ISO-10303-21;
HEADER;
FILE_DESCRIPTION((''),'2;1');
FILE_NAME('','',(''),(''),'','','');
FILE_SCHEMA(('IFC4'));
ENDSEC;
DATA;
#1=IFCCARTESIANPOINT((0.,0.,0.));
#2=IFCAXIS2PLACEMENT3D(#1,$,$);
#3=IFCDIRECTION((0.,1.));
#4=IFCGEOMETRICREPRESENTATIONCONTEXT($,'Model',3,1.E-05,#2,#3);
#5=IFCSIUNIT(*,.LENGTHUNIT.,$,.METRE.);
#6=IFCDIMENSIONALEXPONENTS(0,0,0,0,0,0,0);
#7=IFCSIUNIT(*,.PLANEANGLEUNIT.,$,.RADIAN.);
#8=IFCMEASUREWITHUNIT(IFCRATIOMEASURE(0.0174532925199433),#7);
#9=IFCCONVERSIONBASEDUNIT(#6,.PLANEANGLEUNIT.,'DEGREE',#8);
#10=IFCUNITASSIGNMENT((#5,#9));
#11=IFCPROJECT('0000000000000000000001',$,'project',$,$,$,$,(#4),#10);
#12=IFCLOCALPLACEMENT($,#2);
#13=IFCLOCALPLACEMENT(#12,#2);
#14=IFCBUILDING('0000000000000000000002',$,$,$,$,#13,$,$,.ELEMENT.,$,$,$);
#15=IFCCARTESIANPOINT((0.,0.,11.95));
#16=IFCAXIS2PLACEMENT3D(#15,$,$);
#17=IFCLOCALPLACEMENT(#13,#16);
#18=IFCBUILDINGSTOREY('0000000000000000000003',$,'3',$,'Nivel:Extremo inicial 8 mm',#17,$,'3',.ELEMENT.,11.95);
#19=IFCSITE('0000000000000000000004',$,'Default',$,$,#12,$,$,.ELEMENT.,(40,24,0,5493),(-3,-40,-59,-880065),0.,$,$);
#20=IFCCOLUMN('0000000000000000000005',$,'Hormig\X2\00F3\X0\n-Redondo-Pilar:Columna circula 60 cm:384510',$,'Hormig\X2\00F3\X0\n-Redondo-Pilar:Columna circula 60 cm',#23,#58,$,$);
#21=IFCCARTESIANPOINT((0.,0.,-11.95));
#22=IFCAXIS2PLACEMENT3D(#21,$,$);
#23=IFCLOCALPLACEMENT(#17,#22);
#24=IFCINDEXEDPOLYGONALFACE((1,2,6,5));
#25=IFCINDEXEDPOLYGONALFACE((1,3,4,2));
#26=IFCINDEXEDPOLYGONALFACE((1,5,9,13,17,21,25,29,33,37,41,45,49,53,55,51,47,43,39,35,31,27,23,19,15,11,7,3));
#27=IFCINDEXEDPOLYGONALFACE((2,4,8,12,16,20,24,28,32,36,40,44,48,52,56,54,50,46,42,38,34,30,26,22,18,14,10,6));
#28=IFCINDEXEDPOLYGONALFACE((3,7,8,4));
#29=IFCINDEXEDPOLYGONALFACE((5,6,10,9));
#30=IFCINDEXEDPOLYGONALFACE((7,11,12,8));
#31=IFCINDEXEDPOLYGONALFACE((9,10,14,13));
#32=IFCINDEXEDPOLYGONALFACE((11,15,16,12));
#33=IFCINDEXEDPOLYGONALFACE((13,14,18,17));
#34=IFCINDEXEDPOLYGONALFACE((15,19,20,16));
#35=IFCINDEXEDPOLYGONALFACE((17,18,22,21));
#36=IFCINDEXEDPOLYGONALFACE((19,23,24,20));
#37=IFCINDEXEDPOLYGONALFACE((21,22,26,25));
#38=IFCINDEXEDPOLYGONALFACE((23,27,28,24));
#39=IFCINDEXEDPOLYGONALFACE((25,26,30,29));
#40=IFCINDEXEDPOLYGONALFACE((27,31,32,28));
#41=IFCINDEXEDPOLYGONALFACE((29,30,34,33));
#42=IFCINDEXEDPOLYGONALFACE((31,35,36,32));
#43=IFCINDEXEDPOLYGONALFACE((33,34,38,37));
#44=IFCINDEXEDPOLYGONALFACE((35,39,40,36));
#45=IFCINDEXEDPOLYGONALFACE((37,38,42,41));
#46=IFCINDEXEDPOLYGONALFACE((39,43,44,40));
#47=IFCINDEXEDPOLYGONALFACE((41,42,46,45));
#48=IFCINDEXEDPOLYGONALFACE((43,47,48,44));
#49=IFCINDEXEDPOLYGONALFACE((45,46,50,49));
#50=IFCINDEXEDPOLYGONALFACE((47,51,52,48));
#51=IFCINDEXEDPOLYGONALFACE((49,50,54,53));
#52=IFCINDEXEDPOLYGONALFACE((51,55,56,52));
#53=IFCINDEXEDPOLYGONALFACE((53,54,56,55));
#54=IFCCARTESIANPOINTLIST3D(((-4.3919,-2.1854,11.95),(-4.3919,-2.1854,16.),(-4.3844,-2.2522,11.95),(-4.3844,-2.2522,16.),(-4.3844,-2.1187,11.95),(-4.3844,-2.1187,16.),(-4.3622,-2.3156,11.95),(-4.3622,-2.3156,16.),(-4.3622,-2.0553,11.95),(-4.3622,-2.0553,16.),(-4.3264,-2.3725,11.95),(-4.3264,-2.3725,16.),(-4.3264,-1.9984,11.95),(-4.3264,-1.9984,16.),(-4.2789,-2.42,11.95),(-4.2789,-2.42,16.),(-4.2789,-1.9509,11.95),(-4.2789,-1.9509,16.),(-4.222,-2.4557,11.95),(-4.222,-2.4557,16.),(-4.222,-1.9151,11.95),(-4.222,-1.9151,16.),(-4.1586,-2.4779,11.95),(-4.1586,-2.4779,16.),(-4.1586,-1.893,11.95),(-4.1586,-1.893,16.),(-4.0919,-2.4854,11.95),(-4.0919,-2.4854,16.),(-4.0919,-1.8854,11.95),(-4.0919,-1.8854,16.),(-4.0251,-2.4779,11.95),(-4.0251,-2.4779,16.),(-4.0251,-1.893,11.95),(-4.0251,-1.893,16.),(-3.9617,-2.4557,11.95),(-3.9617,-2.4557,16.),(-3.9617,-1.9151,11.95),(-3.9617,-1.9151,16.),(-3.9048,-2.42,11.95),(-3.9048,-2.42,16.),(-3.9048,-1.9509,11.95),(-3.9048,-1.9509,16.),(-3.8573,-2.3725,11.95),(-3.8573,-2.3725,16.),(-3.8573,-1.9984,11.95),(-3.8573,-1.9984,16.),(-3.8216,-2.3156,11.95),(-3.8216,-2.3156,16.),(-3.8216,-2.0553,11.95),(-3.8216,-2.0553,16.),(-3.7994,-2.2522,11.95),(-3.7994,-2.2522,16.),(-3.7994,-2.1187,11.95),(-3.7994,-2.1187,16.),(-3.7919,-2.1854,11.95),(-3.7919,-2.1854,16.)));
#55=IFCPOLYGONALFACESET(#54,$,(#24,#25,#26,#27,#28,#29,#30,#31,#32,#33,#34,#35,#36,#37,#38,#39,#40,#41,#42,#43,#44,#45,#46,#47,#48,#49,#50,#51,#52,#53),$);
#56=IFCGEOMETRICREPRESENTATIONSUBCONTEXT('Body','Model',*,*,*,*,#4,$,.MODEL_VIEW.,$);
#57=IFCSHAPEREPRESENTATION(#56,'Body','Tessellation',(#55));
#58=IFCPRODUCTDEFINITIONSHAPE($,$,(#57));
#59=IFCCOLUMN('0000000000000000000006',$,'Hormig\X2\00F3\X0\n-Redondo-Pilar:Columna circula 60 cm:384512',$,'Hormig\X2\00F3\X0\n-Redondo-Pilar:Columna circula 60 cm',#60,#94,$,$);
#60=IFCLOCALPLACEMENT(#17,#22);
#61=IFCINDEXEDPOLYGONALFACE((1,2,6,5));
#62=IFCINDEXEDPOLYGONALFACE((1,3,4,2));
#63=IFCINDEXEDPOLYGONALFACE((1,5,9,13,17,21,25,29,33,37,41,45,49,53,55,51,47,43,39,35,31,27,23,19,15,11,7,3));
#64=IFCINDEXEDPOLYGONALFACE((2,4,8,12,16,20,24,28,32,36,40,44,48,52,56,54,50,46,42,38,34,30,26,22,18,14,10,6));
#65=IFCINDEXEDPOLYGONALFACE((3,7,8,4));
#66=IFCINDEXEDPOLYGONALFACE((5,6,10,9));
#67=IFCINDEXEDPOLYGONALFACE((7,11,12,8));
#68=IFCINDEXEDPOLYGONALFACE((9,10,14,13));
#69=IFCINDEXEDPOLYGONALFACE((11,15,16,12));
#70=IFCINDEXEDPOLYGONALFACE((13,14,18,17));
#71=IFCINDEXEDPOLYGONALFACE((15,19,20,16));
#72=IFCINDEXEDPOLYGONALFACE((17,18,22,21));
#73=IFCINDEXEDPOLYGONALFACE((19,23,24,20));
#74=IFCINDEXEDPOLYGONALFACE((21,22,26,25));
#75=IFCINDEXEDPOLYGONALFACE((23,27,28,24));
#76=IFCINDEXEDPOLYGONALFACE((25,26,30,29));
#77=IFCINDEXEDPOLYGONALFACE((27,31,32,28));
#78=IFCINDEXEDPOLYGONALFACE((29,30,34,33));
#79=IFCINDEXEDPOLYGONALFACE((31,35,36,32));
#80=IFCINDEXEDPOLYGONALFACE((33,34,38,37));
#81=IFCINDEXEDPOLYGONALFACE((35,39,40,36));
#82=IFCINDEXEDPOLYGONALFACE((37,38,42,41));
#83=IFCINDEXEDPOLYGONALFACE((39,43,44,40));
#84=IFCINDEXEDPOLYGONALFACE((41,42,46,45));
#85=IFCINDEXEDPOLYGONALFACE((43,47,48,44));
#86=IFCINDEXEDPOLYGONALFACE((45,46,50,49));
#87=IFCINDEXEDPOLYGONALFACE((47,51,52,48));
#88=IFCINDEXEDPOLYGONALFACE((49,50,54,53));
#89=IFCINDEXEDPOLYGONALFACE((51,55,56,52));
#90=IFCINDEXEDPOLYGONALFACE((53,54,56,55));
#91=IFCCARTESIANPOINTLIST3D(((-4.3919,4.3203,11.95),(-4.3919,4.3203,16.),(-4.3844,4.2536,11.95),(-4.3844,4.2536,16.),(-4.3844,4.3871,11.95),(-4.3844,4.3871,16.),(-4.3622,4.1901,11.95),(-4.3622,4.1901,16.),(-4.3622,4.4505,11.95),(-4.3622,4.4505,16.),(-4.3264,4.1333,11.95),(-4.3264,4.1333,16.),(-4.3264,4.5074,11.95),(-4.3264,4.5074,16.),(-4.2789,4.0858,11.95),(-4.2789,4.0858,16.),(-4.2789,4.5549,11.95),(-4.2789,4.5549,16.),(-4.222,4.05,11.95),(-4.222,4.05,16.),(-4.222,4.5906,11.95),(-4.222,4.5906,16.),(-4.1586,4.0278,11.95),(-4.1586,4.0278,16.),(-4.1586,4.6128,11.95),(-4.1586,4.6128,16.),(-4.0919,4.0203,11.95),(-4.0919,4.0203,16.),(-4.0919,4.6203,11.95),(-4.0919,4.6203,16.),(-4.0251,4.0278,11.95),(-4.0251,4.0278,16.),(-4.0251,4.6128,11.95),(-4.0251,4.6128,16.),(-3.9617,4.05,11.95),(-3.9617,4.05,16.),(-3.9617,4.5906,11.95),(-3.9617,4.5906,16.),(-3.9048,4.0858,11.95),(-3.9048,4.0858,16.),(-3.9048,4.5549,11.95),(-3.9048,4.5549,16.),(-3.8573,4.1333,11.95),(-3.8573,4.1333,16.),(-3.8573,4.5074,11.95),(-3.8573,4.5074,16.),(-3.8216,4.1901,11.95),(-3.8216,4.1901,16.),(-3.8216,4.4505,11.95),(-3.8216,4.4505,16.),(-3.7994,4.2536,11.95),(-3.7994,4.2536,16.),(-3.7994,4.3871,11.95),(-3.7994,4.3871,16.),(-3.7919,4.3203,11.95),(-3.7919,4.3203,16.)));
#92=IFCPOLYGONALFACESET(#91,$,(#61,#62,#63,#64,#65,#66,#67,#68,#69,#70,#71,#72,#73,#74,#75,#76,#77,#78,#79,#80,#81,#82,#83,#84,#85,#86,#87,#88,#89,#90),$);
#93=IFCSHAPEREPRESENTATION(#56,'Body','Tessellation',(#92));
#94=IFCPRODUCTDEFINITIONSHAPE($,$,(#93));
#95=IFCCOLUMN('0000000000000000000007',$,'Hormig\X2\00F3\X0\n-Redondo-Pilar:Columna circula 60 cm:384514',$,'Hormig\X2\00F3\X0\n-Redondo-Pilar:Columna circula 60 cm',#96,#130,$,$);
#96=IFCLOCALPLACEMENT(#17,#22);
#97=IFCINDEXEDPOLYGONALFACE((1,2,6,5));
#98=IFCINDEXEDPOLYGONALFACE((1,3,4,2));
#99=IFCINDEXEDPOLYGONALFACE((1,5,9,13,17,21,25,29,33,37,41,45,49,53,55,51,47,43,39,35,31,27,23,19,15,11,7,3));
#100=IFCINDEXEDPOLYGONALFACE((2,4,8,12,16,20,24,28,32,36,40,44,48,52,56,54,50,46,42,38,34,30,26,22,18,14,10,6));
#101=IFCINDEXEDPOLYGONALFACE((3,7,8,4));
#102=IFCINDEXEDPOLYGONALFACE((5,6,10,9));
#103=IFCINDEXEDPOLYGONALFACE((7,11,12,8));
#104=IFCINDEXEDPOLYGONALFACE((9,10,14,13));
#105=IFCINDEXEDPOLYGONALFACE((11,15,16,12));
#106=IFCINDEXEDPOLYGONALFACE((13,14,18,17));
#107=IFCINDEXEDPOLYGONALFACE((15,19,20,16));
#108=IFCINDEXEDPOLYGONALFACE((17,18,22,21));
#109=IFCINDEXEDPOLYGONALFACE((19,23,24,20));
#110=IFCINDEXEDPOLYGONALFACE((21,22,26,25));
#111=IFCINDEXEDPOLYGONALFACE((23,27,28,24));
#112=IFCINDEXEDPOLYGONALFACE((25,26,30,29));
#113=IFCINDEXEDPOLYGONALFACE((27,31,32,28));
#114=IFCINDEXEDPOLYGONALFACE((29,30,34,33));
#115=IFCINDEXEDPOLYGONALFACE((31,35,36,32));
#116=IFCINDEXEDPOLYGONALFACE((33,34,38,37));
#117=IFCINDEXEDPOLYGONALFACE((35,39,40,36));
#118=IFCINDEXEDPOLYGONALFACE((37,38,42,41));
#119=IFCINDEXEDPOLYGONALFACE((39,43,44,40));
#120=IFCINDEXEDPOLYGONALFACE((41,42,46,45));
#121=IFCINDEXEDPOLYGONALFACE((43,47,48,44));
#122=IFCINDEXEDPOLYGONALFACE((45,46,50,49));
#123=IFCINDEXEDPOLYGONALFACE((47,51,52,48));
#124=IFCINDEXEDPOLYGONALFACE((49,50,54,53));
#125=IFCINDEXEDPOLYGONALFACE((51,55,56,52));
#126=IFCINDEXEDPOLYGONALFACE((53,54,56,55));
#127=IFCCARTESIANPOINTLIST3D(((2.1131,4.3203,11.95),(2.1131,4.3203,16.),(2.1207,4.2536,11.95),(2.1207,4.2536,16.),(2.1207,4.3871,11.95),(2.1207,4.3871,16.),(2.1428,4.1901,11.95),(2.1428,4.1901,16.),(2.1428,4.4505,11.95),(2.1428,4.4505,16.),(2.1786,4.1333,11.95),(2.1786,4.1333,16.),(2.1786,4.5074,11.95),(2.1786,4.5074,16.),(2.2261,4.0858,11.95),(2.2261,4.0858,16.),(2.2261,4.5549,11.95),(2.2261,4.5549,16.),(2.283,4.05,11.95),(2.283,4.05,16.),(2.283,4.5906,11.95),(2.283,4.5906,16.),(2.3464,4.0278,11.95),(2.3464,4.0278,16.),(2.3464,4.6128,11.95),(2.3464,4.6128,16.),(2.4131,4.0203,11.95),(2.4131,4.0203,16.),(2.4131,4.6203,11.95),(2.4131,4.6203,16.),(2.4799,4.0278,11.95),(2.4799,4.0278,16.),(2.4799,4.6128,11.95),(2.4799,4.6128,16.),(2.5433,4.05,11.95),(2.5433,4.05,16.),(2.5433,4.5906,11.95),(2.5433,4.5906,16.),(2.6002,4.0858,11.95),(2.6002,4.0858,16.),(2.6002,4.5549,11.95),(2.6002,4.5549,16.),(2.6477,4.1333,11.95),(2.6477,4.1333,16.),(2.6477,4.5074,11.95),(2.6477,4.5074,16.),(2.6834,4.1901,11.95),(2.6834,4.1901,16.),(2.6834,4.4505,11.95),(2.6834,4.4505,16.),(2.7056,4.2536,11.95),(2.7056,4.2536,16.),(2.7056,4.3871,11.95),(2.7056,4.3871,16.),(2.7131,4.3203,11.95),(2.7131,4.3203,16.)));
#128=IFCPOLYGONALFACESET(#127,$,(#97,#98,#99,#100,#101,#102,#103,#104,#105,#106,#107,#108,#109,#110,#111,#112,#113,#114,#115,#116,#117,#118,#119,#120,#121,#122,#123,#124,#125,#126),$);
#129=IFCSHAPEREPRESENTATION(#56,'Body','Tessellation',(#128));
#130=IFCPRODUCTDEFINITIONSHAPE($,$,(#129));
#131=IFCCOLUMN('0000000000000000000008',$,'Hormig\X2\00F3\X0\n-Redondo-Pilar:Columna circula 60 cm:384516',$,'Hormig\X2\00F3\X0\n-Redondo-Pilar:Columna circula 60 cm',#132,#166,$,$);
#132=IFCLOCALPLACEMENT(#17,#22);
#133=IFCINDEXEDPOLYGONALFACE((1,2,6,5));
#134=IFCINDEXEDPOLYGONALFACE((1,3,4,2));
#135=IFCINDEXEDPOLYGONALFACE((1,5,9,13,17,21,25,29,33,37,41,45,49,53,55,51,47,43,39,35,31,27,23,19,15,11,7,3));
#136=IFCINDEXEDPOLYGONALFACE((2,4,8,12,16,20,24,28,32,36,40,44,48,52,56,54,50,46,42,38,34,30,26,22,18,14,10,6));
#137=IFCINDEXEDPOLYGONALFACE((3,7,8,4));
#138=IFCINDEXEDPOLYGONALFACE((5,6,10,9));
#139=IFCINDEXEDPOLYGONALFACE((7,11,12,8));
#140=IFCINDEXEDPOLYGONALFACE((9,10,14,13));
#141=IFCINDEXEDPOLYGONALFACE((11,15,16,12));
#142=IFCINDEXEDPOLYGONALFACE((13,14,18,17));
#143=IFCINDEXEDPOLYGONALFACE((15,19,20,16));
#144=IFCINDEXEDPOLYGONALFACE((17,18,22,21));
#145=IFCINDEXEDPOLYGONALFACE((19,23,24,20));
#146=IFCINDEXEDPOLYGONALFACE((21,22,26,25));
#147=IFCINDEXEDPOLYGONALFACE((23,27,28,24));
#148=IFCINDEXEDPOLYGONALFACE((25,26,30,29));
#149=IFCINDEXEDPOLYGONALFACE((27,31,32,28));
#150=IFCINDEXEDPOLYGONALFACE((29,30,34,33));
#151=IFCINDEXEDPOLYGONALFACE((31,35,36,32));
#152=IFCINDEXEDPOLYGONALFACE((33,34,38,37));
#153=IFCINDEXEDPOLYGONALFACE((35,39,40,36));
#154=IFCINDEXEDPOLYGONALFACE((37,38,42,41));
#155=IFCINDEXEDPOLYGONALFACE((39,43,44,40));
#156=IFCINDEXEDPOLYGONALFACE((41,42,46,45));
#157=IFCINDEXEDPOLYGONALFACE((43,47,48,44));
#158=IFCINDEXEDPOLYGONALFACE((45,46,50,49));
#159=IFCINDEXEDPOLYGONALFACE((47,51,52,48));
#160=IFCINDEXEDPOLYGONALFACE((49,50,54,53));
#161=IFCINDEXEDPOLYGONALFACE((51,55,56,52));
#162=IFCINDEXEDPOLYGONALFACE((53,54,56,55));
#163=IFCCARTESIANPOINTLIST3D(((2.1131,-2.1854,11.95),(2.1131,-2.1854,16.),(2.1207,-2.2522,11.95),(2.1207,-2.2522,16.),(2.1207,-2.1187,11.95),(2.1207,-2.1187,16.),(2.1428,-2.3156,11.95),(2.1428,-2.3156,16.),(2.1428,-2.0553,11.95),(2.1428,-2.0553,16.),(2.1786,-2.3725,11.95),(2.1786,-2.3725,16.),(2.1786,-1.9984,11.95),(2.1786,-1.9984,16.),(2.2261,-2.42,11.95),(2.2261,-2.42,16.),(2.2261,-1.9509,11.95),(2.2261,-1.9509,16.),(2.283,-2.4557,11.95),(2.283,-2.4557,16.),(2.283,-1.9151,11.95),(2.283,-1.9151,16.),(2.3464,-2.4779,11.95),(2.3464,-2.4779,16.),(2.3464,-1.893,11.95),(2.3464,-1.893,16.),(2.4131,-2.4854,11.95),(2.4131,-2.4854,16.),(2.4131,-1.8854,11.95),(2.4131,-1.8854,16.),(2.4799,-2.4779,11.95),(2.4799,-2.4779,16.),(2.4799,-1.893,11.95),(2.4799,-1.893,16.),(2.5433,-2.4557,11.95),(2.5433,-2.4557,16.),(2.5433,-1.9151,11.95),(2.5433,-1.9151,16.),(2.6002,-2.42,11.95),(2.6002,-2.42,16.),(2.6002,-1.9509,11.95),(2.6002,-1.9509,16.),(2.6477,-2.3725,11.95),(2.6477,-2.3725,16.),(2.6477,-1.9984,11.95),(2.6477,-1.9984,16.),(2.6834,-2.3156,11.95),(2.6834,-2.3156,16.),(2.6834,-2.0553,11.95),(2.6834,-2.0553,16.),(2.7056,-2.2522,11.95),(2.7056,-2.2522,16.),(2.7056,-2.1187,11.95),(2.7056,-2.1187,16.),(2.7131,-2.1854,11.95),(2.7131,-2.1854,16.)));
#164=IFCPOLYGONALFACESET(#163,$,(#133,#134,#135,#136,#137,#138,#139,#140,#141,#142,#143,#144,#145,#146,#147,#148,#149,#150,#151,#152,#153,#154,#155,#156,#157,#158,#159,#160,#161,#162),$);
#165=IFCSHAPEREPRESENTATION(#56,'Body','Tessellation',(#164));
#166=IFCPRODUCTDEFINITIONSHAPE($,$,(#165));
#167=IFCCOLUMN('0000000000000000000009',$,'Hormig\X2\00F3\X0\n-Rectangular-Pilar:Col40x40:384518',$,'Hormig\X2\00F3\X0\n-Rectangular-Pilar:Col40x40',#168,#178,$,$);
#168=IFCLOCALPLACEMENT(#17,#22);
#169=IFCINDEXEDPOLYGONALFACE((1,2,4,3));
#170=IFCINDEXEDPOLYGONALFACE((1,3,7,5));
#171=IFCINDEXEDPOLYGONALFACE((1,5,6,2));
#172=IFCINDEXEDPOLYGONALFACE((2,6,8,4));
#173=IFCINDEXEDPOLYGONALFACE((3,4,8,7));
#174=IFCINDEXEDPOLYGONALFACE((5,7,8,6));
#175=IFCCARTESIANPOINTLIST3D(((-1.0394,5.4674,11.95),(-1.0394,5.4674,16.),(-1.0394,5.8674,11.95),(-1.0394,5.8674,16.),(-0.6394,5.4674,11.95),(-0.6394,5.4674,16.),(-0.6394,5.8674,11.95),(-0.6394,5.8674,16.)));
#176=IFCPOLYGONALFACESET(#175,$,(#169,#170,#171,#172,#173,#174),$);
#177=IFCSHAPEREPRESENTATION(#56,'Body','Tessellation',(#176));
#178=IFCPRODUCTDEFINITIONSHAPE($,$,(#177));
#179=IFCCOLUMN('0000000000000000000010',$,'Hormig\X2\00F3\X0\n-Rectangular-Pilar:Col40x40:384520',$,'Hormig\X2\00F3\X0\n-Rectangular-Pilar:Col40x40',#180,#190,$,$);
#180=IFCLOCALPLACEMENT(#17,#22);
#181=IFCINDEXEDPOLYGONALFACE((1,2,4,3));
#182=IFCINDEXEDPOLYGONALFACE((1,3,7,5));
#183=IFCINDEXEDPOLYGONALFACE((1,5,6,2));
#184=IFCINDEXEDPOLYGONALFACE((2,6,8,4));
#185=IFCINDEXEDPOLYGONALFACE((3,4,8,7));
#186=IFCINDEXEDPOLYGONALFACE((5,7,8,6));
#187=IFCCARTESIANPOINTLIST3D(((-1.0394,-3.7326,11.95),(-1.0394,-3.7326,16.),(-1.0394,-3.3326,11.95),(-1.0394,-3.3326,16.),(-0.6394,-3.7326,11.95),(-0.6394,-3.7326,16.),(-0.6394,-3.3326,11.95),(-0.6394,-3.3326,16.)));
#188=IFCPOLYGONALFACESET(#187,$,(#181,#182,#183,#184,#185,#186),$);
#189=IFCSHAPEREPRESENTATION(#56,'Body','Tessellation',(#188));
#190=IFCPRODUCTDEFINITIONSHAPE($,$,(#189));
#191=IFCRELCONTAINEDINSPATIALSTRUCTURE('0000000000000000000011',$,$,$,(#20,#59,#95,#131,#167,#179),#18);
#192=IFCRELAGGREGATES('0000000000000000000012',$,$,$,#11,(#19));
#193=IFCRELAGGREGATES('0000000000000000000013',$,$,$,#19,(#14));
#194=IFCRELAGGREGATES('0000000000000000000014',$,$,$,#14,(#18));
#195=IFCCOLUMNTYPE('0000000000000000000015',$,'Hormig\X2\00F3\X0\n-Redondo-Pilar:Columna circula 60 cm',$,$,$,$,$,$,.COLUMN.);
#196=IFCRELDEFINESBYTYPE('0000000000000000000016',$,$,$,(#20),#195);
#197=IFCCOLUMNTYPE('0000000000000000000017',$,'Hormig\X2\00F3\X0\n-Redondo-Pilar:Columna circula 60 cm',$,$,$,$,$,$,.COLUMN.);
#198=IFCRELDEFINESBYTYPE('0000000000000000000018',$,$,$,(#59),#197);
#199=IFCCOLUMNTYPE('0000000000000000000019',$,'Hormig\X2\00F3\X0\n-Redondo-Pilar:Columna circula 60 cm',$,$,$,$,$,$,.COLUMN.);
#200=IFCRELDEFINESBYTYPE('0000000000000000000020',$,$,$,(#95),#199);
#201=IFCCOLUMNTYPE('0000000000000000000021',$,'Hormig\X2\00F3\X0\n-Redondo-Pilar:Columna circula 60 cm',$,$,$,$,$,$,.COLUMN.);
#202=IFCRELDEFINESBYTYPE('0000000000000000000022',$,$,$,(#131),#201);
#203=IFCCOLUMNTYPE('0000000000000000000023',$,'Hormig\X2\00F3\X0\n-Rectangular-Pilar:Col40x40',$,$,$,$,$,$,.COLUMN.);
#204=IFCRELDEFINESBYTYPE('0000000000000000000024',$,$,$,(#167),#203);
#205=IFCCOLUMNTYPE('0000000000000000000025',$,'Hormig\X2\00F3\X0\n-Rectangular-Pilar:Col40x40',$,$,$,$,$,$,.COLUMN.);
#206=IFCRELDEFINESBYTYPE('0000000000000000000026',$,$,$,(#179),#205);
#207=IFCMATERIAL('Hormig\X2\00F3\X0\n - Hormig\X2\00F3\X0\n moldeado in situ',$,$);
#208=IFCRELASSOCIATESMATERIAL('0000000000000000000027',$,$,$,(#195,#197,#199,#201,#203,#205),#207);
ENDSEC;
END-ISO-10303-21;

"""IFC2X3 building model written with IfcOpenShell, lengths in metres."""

from ifc_helpers import new_model, entity, si_unit, converted_unit, direction, frame, frame_2d, origin, origin_2d_with_axis, place, context, subcontext, project, spatial, rectangle, circle, extrude, source, transform, mapped, material, type_object, type_shapes, element, save


model = new_model("IFC2X3")

# Units and contexts
model_context = context("Model", 3, precision=1e-05, world=origin(), true_north=direction((0.0, 1.0)))
body_context = subcontext(model_context, "Body", "Model", "MODEL_VIEW")
ifc_project = project(units=[si_unit("LENGTHUNIT", "METRE"), converted_unit("PLANEANGLEUNIT", "DEGREE", entity("IfcRatioMeasure", 0.0174532925199433), si_unit("PLANEANGLEUNIT", "RADIAN"), dimensions=[0, 0, 0, 0, 0, 0, 0])], contexts=[model_context])

# Site, building, storey
site_placement = place(None, origin())
site = spatial("IfcSite", under=ifc_project, at=site_placement, Name="Default", CompositionType="ELEMENT", RefLatitude=(40, 24, 0, 5493), RefLongitude=(-3, -40, -59, -880065), RefElevation=0.0)
building_placement = place(site_placement, origin())
building = spatial("IfcBuilding", under=site, at=building_placement, CompositionType="ELEMENT")
storey_placement = place(building_placement, frame((0.0, 0.0, 11.95)))
storey = spatial("IfcBuildingStorey", under=building, at=storey_placement, Name="3", ObjectType="Nivel:Extremo inicial 8 mm", LongName="3", CompositionType="ELEMENT", Elevation=11.95)

# Columns
ifc_material_1 = material(Name="Hormigón - Hormigón moldeado in situ")
column_type_1 = type_object("IfcColumnType", Name="Hormigón-Redondo-Pilar:Columna circula 60 cm", PredefinedType="COLUMN", material=ifc_material_1)
shared_shape_1 = source(origin(), body_context, "Body", "SweptSolid", [
    extrude(circle(Radius=0.3, at=frame_2d((0.0, 0.0), x_axis=(1.0, 0.0))), frame((-4.0919, -2.1854, 11.95)), (0.0, 0.0, 1.0), 4.05),
])
type_shapes(column_type_1, [shared_shape_1])
column_1_placement = place(storey_placement, frame((0.0, 0.0, -11.95)))
element("IfcColumn", 1, at=column_1_placement, inside=storey, type_object=column_type_1, Name="Hormigón-Redondo-Pilar:Columna circula 60 cm:384510", ObjectType="Hormigón-Redondo-Pilar:Columna circula 60 cm", context=body_context, shape_type="MappedRepresentation", body=[
    mapped(shared_shape_1, transform((0.0, 0.0, 0.0), scale=1.0)),
])
column_type_2 = type_object("IfcColumnType", Name="Hormigón-Redondo-Pilar:Columna circula 60 cm", PredefinedType="COLUMN", material=ifc_material_1)
shared_shape_2 = source(origin(), body_context, "Body", "SweptSolid", [
    extrude(circle(Radius=0.3, at=frame_2d((0.0, 0.0), x_axis=(1.0, 0.0))), frame((-4.0919, 4.3203, 11.95)), (0.0, 0.0, 1.0), 4.05),
])
type_shapes(column_type_2, [shared_shape_2])
column_2_placement = place(storey_placement, frame((0.0, 0.0, -11.95)))
element("IfcColumn", 2, at=column_2_placement, inside=storey, type_object=column_type_2, Name="Hormigón-Redondo-Pilar:Columna circula 60 cm:384512", ObjectType="Hormigón-Redondo-Pilar:Columna circula 60 cm", context=body_context, shape_type="MappedRepresentation", body=[
    mapped(shared_shape_2, transform((0.0, 0.0, 0.0), scale=1.0)),
])
column_type_3 = type_object("IfcColumnType", Name="Hormigón-Redondo-Pilar:Columna circula 60 cm", PredefinedType="COLUMN", material=ifc_material_1)
shared_shape_3 = source(origin(), body_context, "Body", "SweptSolid", [
    extrude(circle(Radius=0.3, at=frame_2d((0.0, 0.0), x_axis=(1.0, 0.0))), frame((2.4131, 4.3203, 11.95)), (0.0, 0.0, 1.0), 4.05),
])
type_shapes(column_type_3, [shared_shape_3])
column_3_placement = place(storey_placement, frame((0.0, 0.0, -11.95)))
element("IfcColumn", 3, at=column_3_placement, inside=storey, type_object=column_type_3, Name="Hormigón-Redondo-Pilar:Columna circula 60 cm:384514", ObjectType="Hormigón-Redondo-Pilar:Columna circula 60 cm", context=body_context, shape_type="MappedRepresentation", body=[
    mapped(shared_shape_3, transform((0.0, 0.0, 0.0), scale=1.0)),
])
column_type_4 = type_object("IfcColumnType", Name="Hormigón-Redondo-Pilar:Columna circula 60 cm", PredefinedType="COLUMN", material=ifc_material_1)
shared_shape_4 = source(origin(), body_context, "Body", "SweptSolid", [
    extrude(circle(Radius=0.3, at=frame_2d((0.0, 0.0), x_axis=(1.0, 0.0))), frame((2.4131, -2.1854, 11.95)), (0.0, 0.0, 1.0), 4.05),
])
type_shapes(column_type_4, [shared_shape_4])
column_4_placement = place(storey_placement, frame((0.0, 0.0, -11.95)))
element("IfcColumn", 4, at=column_4_placement, inside=storey, type_object=column_type_4, Name="Hormigón-Redondo-Pilar:Columna circula 60 cm:384516", ObjectType="Hormigón-Redondo-Pilar:Columna circula 60 cm", context=body_context, shape_type="MappedRepresentation", body=[
    mapped(shared_shape_4, transform((0.0, 0.0, 0.0), scale=1.0)),
])
column_type_5 = type_object("IfcColumnType", Name="Hormigón-Rectangular-Pilar:Col40x40", PredefinedType="COLUMN", material=ifc_material_1)
shared_shape_5 = source(origin(), body_context, "Body", "SweptSolid", [
    extrude(rectangle(XDim=0.4, YDim=0.4, at=origin_2d_with_axis()), frame((-0.8394, 5.6674, 11.95), z_axis=(0.0, 0.0, 1.0), x_axis=(0.0, -1.0, 0.0)), (0.0, 0.0, 1.0), 4.05),
])
type_shapes(column_type_5, [shared_shape_5])
column_5_placement = place(storey_placement, frame((0.0, 0.0, -11.95)))
element("IfcColumn", 5, at=column_5_placement, inside=storey, type_object=column_type_5, Name="Hormigón-Rectangular-Pilar:Col40x40:384518", ObjectType="Hormigón-Rectangular-Pilar:Col40x40", context=body_context, shape_type="MappedRepresentation", body=[
    mapped(shared_shape_5, transform((0.0, 0.0, 0.0), scale=1.0)),
])
column_type_6 = type_object("IfcColumnType", Name="Hormigón-Rectangular-Pilar:Col40x40", PredefinedType="COLUMN", material=ifc_material_1)
shared_shape_6 = source(origin(), body_context, "Body", "SweptSolid", [
    extrude(rectangle(XDim=0.4, YDim=0.4, at=origin_2d_with_axis()), frame((-0.8394, -3.5326, 11.95), z_axis=(0.0, 0.0, 1.0), x_axis=(0.0, -1.0, 0.0)), (0.0, 0.0, 1.0), 4.05),
])
type_shapes(column_type_6, [shared_shape_6])
column_6_placement = place(storey_placement, frame((0.0, 0.0, -11.95)))
element("IfcColumn", 6, at=column_6_placement, inside=storey, type_object=column_type_6, Name="Hormigón-Rectangular-Pilar:Col40x40:384520", ObjectType="Hormigón-Rectangular-Pilar:Col40x40", context=body_context, shape_type="MappedRepresentation", body=[
    mapped(shared_shape_6, transform((0.0, 0.0, 0.0), scale=1.0)),
])

save(model, "model.ifc")
